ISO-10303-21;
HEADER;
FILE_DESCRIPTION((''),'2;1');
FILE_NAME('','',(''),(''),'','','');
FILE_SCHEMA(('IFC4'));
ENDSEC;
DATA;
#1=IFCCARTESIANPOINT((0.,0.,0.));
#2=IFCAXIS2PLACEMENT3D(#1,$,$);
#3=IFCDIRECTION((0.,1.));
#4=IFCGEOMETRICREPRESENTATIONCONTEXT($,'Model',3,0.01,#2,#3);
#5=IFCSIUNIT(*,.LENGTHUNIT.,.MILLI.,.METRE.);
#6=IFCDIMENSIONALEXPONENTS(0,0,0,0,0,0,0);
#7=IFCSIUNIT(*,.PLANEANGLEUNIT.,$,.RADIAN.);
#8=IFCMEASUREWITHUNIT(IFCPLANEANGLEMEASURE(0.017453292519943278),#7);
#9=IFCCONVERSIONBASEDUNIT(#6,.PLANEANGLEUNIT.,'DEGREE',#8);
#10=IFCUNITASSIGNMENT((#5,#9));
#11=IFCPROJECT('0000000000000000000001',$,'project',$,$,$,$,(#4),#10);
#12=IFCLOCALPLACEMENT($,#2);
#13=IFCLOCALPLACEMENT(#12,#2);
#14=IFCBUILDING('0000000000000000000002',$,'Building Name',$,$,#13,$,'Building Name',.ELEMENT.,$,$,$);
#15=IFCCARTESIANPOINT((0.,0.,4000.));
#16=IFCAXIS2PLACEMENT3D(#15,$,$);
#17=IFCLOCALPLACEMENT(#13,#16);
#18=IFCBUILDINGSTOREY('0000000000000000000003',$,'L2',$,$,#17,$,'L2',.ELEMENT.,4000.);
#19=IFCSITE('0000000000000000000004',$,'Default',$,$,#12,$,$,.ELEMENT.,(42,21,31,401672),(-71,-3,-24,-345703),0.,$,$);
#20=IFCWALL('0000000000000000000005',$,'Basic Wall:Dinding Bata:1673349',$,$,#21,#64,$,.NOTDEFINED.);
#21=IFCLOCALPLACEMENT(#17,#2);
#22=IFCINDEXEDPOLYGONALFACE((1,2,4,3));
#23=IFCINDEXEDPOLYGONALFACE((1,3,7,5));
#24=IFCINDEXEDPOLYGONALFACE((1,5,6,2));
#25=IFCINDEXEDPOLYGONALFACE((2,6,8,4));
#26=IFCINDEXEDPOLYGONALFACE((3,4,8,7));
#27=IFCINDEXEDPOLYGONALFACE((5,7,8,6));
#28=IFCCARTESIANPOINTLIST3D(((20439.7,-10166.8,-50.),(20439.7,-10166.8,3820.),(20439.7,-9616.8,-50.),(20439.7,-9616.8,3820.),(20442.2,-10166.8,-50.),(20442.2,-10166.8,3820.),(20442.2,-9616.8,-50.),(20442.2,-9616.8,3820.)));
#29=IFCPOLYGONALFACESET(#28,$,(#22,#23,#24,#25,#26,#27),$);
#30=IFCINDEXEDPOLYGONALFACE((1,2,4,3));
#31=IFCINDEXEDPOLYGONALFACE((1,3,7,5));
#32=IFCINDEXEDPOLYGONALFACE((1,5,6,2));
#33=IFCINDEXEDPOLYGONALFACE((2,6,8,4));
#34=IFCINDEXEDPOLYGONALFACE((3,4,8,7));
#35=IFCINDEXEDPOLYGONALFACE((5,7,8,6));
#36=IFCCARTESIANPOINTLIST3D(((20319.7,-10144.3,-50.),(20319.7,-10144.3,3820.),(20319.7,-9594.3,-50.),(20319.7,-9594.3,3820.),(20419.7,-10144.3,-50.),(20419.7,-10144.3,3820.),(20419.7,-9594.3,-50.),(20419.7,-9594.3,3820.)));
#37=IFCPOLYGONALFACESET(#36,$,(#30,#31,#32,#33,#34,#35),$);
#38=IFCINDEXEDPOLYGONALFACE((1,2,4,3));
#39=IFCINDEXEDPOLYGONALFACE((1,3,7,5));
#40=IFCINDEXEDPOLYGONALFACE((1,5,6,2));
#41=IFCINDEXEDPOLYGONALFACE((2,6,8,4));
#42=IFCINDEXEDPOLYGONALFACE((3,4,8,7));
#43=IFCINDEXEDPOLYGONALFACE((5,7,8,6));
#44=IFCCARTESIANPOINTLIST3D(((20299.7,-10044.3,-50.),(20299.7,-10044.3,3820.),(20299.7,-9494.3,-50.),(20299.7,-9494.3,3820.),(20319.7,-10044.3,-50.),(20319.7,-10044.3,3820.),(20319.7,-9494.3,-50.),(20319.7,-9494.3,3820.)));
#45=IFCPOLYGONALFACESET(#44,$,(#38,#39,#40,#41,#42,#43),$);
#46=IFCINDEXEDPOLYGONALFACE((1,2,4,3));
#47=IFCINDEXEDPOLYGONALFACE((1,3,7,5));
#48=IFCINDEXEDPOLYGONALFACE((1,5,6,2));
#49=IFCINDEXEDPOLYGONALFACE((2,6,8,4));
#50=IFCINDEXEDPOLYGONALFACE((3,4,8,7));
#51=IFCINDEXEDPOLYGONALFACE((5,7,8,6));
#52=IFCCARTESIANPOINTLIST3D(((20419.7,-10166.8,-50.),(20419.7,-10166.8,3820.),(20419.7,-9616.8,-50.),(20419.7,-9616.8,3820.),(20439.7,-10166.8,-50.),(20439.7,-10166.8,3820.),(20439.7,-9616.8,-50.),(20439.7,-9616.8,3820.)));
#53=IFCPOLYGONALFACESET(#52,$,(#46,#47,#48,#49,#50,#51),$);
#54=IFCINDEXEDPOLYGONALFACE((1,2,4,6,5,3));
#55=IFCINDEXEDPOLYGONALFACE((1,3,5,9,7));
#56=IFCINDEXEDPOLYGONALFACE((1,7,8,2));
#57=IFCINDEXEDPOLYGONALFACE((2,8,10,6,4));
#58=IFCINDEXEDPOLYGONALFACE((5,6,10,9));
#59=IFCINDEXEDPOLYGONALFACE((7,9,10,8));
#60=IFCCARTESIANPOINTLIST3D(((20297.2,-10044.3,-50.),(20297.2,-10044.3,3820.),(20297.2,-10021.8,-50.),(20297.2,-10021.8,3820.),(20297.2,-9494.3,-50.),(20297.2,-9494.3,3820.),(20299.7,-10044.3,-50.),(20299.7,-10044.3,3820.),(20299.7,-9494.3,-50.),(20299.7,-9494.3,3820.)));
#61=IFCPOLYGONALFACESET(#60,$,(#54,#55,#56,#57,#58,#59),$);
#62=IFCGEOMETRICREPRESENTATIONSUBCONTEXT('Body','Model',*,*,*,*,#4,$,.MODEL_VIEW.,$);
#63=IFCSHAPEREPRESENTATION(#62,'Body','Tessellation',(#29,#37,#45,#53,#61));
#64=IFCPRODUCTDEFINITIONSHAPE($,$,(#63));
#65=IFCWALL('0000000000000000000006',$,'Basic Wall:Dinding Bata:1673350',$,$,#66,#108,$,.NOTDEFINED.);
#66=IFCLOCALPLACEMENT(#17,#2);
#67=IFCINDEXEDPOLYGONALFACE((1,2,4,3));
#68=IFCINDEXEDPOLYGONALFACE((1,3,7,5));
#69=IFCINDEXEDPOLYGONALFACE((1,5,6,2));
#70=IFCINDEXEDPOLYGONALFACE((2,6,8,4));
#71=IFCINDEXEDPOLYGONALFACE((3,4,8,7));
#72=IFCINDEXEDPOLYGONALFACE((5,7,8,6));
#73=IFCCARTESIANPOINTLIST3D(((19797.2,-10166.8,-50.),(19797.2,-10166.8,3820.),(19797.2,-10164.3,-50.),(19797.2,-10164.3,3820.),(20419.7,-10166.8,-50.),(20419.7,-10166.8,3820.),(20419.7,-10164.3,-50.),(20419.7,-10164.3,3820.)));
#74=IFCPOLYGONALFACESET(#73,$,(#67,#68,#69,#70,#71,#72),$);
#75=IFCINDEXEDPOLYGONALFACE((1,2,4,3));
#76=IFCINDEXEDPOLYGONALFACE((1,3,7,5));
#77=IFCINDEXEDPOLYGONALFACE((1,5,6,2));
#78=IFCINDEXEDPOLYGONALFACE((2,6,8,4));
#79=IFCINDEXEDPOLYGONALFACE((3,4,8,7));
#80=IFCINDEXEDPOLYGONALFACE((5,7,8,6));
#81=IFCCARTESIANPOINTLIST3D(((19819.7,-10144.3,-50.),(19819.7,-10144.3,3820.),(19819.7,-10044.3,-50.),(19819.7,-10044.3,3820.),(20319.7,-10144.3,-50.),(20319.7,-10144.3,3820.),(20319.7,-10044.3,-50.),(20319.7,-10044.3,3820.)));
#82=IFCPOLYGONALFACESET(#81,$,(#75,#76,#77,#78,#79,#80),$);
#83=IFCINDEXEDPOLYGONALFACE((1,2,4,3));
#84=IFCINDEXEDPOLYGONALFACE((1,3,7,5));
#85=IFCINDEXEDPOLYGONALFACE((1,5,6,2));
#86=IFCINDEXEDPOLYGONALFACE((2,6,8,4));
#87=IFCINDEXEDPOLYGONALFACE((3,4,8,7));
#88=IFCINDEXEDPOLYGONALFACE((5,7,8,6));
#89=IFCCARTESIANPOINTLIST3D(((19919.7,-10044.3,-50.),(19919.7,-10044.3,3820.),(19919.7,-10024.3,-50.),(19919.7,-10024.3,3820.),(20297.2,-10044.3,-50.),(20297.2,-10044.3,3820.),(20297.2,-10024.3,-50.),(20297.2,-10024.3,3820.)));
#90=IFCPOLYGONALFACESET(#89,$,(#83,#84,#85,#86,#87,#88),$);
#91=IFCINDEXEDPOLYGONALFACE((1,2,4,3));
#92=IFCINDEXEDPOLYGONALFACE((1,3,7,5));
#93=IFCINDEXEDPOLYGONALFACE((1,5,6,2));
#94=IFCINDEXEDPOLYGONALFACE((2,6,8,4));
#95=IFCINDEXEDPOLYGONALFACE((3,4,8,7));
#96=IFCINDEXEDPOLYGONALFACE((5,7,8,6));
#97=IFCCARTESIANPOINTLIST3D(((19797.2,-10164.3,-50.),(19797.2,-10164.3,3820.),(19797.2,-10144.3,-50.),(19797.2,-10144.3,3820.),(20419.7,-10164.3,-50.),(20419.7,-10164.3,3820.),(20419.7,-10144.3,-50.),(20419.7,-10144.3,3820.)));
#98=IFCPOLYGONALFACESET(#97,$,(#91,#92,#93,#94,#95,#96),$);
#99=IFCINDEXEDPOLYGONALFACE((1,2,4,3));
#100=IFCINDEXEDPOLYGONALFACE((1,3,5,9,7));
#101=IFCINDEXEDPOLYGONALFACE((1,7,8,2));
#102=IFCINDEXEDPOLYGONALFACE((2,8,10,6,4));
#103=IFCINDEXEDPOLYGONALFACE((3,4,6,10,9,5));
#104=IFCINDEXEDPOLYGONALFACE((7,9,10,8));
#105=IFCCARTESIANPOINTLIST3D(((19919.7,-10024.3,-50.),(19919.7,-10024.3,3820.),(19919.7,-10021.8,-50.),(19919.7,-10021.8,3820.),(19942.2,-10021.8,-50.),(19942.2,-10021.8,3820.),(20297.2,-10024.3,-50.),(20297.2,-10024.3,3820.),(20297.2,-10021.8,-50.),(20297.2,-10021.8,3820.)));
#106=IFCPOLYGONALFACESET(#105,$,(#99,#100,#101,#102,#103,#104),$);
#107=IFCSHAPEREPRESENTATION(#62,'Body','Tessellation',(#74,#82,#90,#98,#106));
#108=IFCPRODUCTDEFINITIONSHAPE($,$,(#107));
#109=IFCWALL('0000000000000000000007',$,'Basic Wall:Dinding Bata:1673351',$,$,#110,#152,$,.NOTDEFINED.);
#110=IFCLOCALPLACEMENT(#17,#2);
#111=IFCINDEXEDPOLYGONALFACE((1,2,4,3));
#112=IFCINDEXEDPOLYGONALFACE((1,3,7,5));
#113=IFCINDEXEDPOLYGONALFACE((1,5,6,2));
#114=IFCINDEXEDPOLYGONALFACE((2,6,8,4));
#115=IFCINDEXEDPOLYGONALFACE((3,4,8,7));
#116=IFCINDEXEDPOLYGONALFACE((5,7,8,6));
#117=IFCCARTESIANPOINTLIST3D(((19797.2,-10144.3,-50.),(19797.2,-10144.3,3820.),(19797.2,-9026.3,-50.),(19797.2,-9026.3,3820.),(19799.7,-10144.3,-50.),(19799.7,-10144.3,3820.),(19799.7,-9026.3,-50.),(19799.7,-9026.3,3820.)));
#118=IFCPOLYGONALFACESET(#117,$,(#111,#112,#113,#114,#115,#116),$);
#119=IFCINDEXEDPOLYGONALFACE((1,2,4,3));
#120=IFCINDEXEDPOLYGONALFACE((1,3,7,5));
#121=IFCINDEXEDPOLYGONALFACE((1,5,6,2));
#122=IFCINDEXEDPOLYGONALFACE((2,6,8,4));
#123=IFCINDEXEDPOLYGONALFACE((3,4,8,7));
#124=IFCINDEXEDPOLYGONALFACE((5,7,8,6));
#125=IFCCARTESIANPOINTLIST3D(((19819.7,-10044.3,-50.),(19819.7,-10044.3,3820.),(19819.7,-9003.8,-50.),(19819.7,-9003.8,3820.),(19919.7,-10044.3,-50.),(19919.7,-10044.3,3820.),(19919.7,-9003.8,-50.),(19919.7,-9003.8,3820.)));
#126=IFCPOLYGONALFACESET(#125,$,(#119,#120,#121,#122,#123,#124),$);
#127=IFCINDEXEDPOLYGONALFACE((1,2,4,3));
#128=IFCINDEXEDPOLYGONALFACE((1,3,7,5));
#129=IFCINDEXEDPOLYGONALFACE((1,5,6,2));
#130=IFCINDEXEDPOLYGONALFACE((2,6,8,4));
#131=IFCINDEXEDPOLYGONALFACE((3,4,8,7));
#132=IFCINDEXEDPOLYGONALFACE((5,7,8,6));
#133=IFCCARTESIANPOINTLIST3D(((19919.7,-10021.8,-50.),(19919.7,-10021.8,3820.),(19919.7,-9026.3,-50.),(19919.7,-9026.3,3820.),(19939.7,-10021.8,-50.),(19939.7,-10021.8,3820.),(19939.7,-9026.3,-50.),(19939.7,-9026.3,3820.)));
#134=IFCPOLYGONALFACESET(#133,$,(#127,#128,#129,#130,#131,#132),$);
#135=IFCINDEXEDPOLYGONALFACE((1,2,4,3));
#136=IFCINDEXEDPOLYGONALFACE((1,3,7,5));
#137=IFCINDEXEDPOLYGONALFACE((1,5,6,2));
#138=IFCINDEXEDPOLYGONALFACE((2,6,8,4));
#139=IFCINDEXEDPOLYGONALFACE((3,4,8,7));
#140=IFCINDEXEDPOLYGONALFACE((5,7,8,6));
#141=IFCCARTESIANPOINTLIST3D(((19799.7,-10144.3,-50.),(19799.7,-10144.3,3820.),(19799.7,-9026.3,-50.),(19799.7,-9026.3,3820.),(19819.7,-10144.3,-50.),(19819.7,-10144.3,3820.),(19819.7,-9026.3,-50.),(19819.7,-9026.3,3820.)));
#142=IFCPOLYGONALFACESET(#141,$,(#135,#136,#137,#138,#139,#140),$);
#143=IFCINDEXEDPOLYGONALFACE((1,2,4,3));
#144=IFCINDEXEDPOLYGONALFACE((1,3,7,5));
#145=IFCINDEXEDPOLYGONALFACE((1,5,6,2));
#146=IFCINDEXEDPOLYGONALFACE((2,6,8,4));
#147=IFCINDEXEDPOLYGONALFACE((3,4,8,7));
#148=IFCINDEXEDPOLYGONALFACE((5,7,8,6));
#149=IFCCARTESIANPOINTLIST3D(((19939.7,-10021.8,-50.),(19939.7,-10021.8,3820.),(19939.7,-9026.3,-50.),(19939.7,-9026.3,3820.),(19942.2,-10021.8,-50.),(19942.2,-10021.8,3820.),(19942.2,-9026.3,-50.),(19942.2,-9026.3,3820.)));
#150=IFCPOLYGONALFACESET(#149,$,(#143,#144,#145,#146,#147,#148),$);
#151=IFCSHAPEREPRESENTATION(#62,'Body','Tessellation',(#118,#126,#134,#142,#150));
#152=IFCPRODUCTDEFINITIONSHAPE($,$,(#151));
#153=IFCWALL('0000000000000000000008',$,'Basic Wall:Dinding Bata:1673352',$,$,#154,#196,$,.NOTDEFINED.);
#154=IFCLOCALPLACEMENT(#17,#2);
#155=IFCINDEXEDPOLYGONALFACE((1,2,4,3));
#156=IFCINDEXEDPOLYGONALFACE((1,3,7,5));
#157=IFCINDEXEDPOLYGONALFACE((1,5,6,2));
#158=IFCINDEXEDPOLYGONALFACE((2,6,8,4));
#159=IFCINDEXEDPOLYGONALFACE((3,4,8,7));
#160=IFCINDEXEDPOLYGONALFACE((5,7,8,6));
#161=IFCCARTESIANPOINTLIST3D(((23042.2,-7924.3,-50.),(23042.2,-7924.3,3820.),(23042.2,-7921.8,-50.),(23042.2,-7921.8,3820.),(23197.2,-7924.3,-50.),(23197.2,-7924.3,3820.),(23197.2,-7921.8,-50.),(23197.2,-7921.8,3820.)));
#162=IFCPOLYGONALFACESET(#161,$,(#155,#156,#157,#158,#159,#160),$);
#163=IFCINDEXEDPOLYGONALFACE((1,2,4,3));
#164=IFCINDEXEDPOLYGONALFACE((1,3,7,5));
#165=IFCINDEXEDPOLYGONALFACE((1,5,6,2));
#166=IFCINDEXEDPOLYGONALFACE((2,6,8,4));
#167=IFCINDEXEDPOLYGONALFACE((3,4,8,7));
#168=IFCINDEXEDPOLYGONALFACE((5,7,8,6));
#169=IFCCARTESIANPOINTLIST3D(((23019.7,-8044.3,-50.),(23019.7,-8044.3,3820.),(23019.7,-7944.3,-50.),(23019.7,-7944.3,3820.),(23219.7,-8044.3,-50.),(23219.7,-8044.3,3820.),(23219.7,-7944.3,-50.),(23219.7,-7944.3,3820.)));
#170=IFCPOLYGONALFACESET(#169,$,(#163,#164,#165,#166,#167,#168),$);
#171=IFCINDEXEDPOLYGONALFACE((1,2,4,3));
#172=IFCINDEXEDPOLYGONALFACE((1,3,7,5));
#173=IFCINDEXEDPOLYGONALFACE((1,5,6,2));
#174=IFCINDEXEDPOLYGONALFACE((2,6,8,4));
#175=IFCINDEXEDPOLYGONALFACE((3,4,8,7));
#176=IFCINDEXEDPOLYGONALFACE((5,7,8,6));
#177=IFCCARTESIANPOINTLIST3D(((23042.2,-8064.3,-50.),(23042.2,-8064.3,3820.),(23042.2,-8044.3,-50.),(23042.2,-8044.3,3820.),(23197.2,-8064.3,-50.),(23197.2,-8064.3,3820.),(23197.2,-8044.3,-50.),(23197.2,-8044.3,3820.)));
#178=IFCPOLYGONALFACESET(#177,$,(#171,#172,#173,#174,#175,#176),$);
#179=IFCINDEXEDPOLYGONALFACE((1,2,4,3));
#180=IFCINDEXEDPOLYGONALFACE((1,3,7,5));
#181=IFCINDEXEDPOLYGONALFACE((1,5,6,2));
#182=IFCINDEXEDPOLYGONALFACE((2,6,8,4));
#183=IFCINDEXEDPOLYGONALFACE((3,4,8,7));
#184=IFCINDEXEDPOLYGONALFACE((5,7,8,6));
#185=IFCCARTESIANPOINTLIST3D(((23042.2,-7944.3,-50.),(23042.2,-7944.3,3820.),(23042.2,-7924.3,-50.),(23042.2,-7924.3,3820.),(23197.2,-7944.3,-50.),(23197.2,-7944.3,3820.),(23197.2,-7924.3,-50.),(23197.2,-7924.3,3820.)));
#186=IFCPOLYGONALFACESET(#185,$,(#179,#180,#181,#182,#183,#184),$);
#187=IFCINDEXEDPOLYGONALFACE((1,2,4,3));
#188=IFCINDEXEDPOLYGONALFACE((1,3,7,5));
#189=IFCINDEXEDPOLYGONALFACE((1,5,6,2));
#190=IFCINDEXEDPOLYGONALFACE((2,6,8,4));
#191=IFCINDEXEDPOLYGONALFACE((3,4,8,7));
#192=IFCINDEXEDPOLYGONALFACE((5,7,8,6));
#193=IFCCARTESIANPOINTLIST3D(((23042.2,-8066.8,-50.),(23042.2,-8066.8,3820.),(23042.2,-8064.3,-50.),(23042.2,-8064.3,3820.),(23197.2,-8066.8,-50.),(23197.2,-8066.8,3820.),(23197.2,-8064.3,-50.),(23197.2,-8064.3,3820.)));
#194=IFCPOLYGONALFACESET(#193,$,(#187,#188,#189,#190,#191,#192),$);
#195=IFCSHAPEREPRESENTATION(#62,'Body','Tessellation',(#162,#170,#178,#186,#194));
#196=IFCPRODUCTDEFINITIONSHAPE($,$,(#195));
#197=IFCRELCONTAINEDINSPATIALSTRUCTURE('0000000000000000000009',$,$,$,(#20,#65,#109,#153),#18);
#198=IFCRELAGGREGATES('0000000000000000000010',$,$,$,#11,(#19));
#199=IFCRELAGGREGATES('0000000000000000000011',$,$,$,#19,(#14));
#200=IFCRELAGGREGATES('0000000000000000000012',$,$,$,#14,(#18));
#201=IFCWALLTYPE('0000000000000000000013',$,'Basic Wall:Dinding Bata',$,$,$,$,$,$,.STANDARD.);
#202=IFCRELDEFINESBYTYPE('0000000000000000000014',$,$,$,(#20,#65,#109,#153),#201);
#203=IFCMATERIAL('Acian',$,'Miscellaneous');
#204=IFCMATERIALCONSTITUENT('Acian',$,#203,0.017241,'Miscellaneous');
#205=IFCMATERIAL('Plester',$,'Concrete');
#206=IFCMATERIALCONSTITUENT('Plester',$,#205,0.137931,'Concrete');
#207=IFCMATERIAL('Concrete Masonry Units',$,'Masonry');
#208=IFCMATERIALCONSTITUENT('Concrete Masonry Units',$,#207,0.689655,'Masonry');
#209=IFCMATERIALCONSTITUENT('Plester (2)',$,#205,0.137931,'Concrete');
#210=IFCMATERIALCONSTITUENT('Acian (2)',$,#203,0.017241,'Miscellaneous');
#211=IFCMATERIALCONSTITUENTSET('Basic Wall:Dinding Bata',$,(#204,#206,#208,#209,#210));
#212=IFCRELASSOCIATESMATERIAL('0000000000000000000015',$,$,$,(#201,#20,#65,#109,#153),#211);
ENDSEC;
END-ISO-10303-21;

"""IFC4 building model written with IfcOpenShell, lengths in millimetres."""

from ifc_helpers import new_model, entity, si_unit, converted_unit, direction, frame, origin, place, context, subcontext, project, spatial, indexed_curve, outline, extrude, material, constituent, constituent_set, type_object, element, save


model = new_model("IFC4")

# Units and contexts
model_context = context("Model", 3, precision=0.01, world=origin(), true_north=direction((0.0, 1.0)))
body_context = subcontext(model_context, "Body", "Model", "MODEL_VIEW")
ifc_project = project(units=[si_unit("LENGTHUNIT", "METRE", prefix="MILLI"), converted_unit("PLANEANGLEUNIT", "DEGREE", entity("IfcPlaneAngleMeasure", 0.017453292519943278), si_unit("PLANEANGLEUNIT", "RADIAN"), dimensions=[0, 0, 0, 0, 0, 0, 0])], contexts=[model_context])

# Site, building, storey
site_placement = place(None, origin())
site = spatial("IfcSite", under=ifc_project, at=site_placement, Name="Default", CompositionType="ELEMENT", RefLatitude=(42, 21, 31, 401672), RefLongitude=(-71, -3, -24, -345703), RefElevation=0.0)
building_placement = place(site_placement, origin())
building = spatial("IfcBuilding", under=site, at=building_placement, Name="Building Name", LongName="Building Name", CompositionType="ELEMENT")
storey_placement = place(building_placement, frame((0.0, 0.0, 4000.0)))
storey = spatial("IfcBuildingStorey", under=building, at=storey_placement, Name="L2", LongName="L2", CompositionType="ELEMENT", Elevation=4000.0)

# Walls
ifc_material_1 = material(Name="Acian", Category="Miscellaneous")
ifc_constituent_1 = constituent(ifc_material_1, Name="Acian", Category="Miscellaneous", fraction=0.017241)
ifc_material_2 = material(Name="Plester", Category="Concrete")
ifc_constituent_2 = constituent(ifc_material_2, Name="Plester", Category="Concrete", fraction=0.137931)
ifc_material_3 = material(Name="Concrete Masonry Units", Category="Masonry")
ifc_constituent_3 = constituent(ifc_material_3, Name="Concrete Masonry Units", Category="Masonry", fraction=0.689655)
ifc_constituent_4 = constituent(ifc_material_2, Name="Plester (2)", Category="Concrete", fraction=0.137931)
ifc_constituent_5 = constituent(ifc_material_1, Name="Acian (2)", Category="Miscellaneous", fraction=0.017241)
ifc_constituent_set = constituent_set(constituents=[ifc_constituent_1, ifc_constituent_2, ifc_constituent_3, ifc_constituent_4, ifc_constituent_5], Name="Basic Wall:Dinding Bata")
wall_type = type_object("IfcWallType", Name="Basic Wall:Dinding Bata", PredefinedType="STANDARD", material=ifc_constituent_set)
wall_1_placement = place(storey_placement, frame((20369.7, -9616.8, -50.0), z_axis=(0.0, 0.0, 1.0), x_axis=(0.0, -1.0, 0.0)))
element("IfcWall", 1, at=wall_1_placement, inside=storey, type_object=wall_type, material=ifc_constituent_set, Name="Basic Wall:Dinding Bata:1673349", PredefinedType="NOTDEFINED", context=body_context, shape_type="SweptSolid", body=[
    extrude(outline(indexed_curve([(-1.2, -275.0), (1.2, -275.0), (1.2, 275.0), (-1.2, 275.0), (-1.2, -275.0)], self_intersect=False)), frame((275.0, 71.3, 0.0), z_axis=(0.0, 0.0, 1.0), x_axis=(0.0, -1.0, 0.0)), (0.0, 0.0, 1.0), 3870.0),
    extrude(outline(indexed_curve([(-275.0, -50.0), (275.0, -50.0), (275.0, 50.0), (-275.0, 50.0), (-275.0, -50.0)], self_intersect=False)), frame((252.5, 0.0, 0.0)), (0.0, 0.0, 1.0), 3870.0),
    extrude(outline(indexed_curve([(-275.0, -10.0), (275.0, -10.0), (275.0, 10.0), (-275.0, 10.0), (-275.0, -10.0)], self_intersect=False)), frame((152.5, -60.0, 0.0)), (0.0, 0.0, 1.0), 3870.0),
    extrude(outline(indexed_curve([(-275.0, -10.0), (275.0, -10.0), (275.0, 10.0), (-275.0, 10.0), (-275.0, -10.0)], self_intersect=False)), frame((275.0, 60.0, 0.0)), (0.0, 0.0, 1.0), 3870.0),
    extrude(outline(indexed_curve([(202.0, -1.0), (224.5, -1.0), (224.5, 1.5), (-325.5, 1.5), (-325.5, -1.0), (202.0, -1.0)], self_intersect=False)), frame((203.0, -71.5, 0.0)), (0.0, 0.0, 1.0), 3870.0),
])
wall_2_placement = place(storey_placement, frame((20297.2, -10094.3, -50.0), z_axis=(0.0, 0.0, 1.0), x_axis=(-1.0, 0.0, 0.0)))
element("IfcWall", 2, at=wall_2_placement, inside=storey, type_object=wall_type, material=ifc_constituent_set, Name="Basic Wall:Dinding Bata:1673350", PredefinedType="NOTDEFINED", context=body_context, shape_type="SweptSolid", body=[
    extrude(outline(indexed_curve([(-1.3, -311.3), (1.2, -311.3), (1.3, 311.3), (-1.2, 311.3), (-1.3, -311.3)], self_intersect=False)), frame((188.8, 71.3, 0.0), z_axis=(0.0, 0.0, 1.0), x_axis=(0.0, -1.0, 0.0)), (0.0, 0.0, 1.0), 3870.0),
    extrude(outline(indexed_curve([(-250.0, -50.0), (250.0, -50.0), (250.0, 50.0), (-250.0, 50.0), (-250.0, -50.0)], self_intersect=False)), frame((227.5, 0.0, 0.0)), (0.0, 0.0, 1.0), 3870.0),
    extrude(outline(indexed_curve([(-188.8, -10.0), (188.8, -10.0), (188.8, 10.0), (-188.8, 10.0), (-188.8, -10.0)], self_intersect=False)), frame((188.8, -60.0, 0.0)), (0.0, 0.0, 1.0), 3870.0),
    extrude(outline(indexed_curve([(-311.3, -10.0), (311.3, -10.0), (311.3, 10.0), (-311.3, 10.0), (-311.3, -10.0)], self_intersect=False)), frame((188.8, 60.0, 0.0)), (0.0, 0.0, 1.0), 3870.0),
    extrude(outline(indexed_curve([(133.0, -1.0), (155.5, -1.0), (155.5, 1.5), (-222.0, 1.5), (-222.0, -1.0), (133.0, -1.0)], self_intersect=False)), frame((222.0, -71.5, 0.0)), (0.0, 0.0, 1.0), 3870.0),
])
wall_3_placement = place(storey_placement, frame((19869.7, -10021.8, -50.0), z_axis=(0.0, 0.0, 1.0), x_axis=(0.0, 1.0, 0.0)))
element("IfcWall", 3, at=wall_3_placement, inside=storey, type_object=wall_type, material=ifc_constituent_set, Name="Basic Wall:Dinding Bata:1673351", PredefinedType="NOTDEFINED", context=body_context, shape_type="SweptSolid", body=[
    extrude(outline(indexed_curve([(-1.2, -559.0), (1.2, -559.0), (1.2, 559.0), (-1.2, 559.0), (-1.2, -559.0)], self_intersect=False)), frame((436.5, 71.3, 0.0), z_axis=(0.0, 0.0, 1.0), x_axis=(0.0, -1.0, 0.0)), (0.0, 0.0, 1.0), 3870.0),
    extrude(outline(indexed_curve([(-520.2, -50.0), (520.2, -50.0), (520.2, 50.0), (-520.2, 50.0), (-520.2, -50.0)], self_intersect=False)), frame((497.7, 0.0, 0.0)), (0.0, 0.0, 1.0), 3870.0),
    extrude(outline(indexed_curve([(-497.7, -10.0), (497.7, -10.0), (497.7, 10.0), (-497.7, 10.0), (-497.7, -10.0)], self_intersect=False)), frame((497.7, -60.0, 0.0)), (0.0, 0.0, 1.0), 3870.0),
    extrude(outline(indexed_curve([(-559.0, -10.0), (559.0, -10.0), (559.0, 10.0), (-559.0, 10.0), (-559.0, -10.0)], self_intersect=False)), frame((436.5, 60.0, 0.0)), (0.0, 0.0, 1.0), 3870.0),
    extrude(outline(indexed_curve([(-1.2, -497.7), (1.2, -497.7), (1.2, 497.7), (-1.2, 497.7), (-1.2, -497.7)], self_intersect=False)), frame((497.7, -71.3, 0.0), z_axis=(0.0, 0.0, 1.0), x_axis=(0.0, 1.0, 0.0)), (0.0, 0.0, 1.0), 3870.0),
])
wall_4_placement = place(storey_placement, frame((23042.2, -7994.3, -50.0)))
element("IfcWall", 4, at=wall_4_placement, inside=storey, type_object=wall_type, material=ifc_constituent_set, Name="Basic Wall:Dinding Bata:1673352", PredefinedType="NOTDEFINED", context=body_context, shape_type="SweptSolid", body=[
    extrude(outline(indexed_curve([(-1.2, -77.5), (1.2, -77.5), (1.2, 77.5), (-1.2, 77.5), (-1.2, -77.5)], self_intersect=False)), frame((77.5, 71.3, 0.0), z_axis=(0.0, 0.0, 1.0), x_axis=(0.0, -1.0, 0.0)), (0.0, 0.0, 1.0), 3870.0),
    extrude(outline(indexed_curve([(-100.0, -50.0), (100.0, -50.0), (100.0, 50.0), (-100.0, 50.0), (-100.0, -50.0)], self_intersect=False)), frame((77.5, 0.0, 0.0)), (0.0, 0.0, 1.0), 3870.0),
    extrude(outline(indexed_curve([(-77.5, -10.0), (77.5, -10.0), (77.5, 10.0), (-77.5, 10.0), (-77.5, -10.0)], self_intersect=False)), frame((77.5, -60.0, 0.0)), (0.0, 0.0, 1.0), 3870.0),
    extrude(outline(indexed_curve([(-77.5, -10.0), (77.5, -10.0), (77.5, 10.0), (-77.5, 10.0), (-77.5, -10.0)], self_intersect=False)), frame((77.5, 60.0, 0.0)), (0.0, 0.0, 1.0), 3870.0),
    extrude(outline(indexed_curve([(-1.2, -77.5), (1.2, -77.5), (1.2, 77.5), (-1.2, 77.5), (-1.2, -77.5)], self_intersect=False)), frame((77.5, -71.3, 0.0), z_axis=(0.0, 0.0, 1.0), x_axis=(0.0, 1.0, 0.0)), (0.0, 0.0, 1.0), 3870.0),
])

save(model, "model.ifc")
